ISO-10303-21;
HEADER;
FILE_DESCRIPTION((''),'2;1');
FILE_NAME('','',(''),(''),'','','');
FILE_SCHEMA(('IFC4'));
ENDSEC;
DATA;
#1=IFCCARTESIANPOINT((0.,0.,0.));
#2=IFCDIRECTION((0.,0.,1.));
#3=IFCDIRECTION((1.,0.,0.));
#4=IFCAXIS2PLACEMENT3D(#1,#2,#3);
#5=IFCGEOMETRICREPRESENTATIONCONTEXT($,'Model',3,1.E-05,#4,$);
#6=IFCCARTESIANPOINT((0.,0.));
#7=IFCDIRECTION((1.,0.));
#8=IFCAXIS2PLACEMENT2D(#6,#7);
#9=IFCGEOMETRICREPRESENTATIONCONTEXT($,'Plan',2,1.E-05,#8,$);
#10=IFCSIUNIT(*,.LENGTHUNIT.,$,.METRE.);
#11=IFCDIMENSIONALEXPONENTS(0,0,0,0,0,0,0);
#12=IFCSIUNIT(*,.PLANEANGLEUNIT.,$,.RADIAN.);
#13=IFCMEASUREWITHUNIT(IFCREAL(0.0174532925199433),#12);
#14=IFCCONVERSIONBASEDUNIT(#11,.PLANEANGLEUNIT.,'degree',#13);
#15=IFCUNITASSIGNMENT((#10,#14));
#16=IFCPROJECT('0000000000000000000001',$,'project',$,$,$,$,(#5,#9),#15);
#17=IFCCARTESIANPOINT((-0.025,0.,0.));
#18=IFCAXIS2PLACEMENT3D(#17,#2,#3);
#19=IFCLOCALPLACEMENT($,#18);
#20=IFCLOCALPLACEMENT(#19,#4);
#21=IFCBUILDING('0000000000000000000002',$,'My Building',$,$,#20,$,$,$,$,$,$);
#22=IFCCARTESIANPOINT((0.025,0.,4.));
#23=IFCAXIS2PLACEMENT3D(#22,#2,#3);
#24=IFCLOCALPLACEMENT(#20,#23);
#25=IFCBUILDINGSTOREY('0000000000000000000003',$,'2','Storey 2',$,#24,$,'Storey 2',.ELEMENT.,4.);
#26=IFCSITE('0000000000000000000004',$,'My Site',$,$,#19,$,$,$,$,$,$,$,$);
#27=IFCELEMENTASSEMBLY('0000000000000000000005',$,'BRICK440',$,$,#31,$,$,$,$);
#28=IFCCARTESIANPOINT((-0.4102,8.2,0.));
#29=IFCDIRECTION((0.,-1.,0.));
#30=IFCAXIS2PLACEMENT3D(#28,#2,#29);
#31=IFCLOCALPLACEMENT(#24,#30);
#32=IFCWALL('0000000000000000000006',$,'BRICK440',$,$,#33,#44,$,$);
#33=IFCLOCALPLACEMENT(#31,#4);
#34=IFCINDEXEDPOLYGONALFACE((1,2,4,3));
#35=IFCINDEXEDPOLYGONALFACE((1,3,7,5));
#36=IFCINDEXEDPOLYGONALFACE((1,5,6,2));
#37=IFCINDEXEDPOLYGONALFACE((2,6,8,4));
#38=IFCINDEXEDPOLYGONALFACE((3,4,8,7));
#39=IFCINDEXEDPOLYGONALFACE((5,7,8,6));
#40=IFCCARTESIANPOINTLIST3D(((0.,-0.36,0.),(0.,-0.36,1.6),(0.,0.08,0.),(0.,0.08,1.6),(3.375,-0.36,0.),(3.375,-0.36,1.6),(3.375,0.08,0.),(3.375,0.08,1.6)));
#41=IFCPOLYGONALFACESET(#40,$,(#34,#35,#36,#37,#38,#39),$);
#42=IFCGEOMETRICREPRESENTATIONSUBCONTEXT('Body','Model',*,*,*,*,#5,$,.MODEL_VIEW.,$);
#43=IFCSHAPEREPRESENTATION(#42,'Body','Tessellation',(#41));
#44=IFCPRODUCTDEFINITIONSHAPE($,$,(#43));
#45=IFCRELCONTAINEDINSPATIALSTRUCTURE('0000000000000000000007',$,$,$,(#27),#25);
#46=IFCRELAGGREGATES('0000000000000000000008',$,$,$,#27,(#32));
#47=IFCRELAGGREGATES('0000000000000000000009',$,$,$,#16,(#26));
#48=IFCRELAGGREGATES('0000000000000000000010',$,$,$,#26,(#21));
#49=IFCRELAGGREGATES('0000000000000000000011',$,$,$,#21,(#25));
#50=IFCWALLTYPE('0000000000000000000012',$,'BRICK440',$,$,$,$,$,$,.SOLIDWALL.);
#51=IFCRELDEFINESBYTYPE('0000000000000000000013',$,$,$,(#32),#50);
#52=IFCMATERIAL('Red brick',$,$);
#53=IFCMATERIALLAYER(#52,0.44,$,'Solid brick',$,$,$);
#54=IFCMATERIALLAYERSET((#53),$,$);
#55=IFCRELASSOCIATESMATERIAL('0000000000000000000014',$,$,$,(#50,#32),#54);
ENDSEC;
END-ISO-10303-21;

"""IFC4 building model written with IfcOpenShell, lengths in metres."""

from ifc_helpers import new_model, entity, si_unit, converted_unit, frame, origin, origin_with_axes, origin_2d_with_axis, place, context, subcontext, project, spatial, polyline, outline, extrude, material, layer, layer_set, layer_usage, type_object, element, aggregate, save


model = new_model("IFC4")

# Units and contexts
model_context = context("Model", 3, precision=1e-05, world=origin_with_axes())
plan_context = context("Plan", 2, precision=1e-05, world=origin_2d_with_axis())
body_context = subcontext(model_context, "Body", "Model", "MODEL_VIEW")
ifc_project = project(units=[si_unit("LENGTHUNIT", "METRE"), converted_unit("PLANEANGLEUNIT", "degree", entity("IfcReal", 0.0174532925199433), si_unit("PLANEANGLEUNIT", "RADIAN"), dimensions=[0, 0, 0, 0, 0, 0, 0])], contexts=[model_context, plan_context])

# Site, building, storey
site_placement = place(None, frame((-0.025, 0.0, 0.0), z_axis=(0.0, 0.0, 1.0), x_axis=(1.0, 0.0, 0.0)))
site = spatial("IfcSite", under=ifc_project, at=site_placement, Name="My Site")
building_placement = place(site_placement, origin_with_axes())
building = spatial("IfcBuilding", under=site, at=building_placement, Name="My Building")
storey_placement = place(building_placement, frame((0.025, 0.0, 4.0), z_axis=(0.0, 0.0, 1.0), x_axis=(1.0, 0.0, 0.0)))
storey = spatial("IfcBuildingStorey", under=building, at=storey_placement, Name="2", Description="Storey 2", LongName="Storey 2", CompositionType="ELEMENT", Elevation=4.0)

# Element assembly, wall
assembly_placement = place(storey_placement, frame((-0.4102, 8.2, 0.0), z_axis=(0.0, 0.0, 1.0), x_axis=(0.0, -1.0, 0.0)))
assembly = element("IfcElementAssembly", 1, at=assembly_placement, inside=storey, Name="BRICK440")
ifc_material = material(Name="Red brick")
ifc_layer = layer(ifc_material, 0.44, Name="Solid brick")
ifc_layer_set = layer_set([ifc_layer])
ifc_layer_usage = layer_usage(ifc_layer_set, "AXIS2", "POSITIVE", -0.36)
wall_type = type_object("IfcWallType", Name="BRICK440", PredefinedType="SOLIDWALL", material=ifc_layer_set)
wall_placement = place(assembly_placement, origin_with_axes())
wall = element("IfcWall", 2, at=wall_placement, type_object=wall_type, material=ifc_layer_usage, Name="BRICK440", context=body_context, shape_type="SweptSolid", body=[
    extrude(outline(polyline([(0.0, 0.08), (0.0, -0.36), (3.375, -0.36), (3.375, 0.08), (0.0, 0.08)])), origin(), (0.0, 0.0, 1.0), 1.6),
])
aggregate(assembly, [wall])

save(model, "model.ifc")
